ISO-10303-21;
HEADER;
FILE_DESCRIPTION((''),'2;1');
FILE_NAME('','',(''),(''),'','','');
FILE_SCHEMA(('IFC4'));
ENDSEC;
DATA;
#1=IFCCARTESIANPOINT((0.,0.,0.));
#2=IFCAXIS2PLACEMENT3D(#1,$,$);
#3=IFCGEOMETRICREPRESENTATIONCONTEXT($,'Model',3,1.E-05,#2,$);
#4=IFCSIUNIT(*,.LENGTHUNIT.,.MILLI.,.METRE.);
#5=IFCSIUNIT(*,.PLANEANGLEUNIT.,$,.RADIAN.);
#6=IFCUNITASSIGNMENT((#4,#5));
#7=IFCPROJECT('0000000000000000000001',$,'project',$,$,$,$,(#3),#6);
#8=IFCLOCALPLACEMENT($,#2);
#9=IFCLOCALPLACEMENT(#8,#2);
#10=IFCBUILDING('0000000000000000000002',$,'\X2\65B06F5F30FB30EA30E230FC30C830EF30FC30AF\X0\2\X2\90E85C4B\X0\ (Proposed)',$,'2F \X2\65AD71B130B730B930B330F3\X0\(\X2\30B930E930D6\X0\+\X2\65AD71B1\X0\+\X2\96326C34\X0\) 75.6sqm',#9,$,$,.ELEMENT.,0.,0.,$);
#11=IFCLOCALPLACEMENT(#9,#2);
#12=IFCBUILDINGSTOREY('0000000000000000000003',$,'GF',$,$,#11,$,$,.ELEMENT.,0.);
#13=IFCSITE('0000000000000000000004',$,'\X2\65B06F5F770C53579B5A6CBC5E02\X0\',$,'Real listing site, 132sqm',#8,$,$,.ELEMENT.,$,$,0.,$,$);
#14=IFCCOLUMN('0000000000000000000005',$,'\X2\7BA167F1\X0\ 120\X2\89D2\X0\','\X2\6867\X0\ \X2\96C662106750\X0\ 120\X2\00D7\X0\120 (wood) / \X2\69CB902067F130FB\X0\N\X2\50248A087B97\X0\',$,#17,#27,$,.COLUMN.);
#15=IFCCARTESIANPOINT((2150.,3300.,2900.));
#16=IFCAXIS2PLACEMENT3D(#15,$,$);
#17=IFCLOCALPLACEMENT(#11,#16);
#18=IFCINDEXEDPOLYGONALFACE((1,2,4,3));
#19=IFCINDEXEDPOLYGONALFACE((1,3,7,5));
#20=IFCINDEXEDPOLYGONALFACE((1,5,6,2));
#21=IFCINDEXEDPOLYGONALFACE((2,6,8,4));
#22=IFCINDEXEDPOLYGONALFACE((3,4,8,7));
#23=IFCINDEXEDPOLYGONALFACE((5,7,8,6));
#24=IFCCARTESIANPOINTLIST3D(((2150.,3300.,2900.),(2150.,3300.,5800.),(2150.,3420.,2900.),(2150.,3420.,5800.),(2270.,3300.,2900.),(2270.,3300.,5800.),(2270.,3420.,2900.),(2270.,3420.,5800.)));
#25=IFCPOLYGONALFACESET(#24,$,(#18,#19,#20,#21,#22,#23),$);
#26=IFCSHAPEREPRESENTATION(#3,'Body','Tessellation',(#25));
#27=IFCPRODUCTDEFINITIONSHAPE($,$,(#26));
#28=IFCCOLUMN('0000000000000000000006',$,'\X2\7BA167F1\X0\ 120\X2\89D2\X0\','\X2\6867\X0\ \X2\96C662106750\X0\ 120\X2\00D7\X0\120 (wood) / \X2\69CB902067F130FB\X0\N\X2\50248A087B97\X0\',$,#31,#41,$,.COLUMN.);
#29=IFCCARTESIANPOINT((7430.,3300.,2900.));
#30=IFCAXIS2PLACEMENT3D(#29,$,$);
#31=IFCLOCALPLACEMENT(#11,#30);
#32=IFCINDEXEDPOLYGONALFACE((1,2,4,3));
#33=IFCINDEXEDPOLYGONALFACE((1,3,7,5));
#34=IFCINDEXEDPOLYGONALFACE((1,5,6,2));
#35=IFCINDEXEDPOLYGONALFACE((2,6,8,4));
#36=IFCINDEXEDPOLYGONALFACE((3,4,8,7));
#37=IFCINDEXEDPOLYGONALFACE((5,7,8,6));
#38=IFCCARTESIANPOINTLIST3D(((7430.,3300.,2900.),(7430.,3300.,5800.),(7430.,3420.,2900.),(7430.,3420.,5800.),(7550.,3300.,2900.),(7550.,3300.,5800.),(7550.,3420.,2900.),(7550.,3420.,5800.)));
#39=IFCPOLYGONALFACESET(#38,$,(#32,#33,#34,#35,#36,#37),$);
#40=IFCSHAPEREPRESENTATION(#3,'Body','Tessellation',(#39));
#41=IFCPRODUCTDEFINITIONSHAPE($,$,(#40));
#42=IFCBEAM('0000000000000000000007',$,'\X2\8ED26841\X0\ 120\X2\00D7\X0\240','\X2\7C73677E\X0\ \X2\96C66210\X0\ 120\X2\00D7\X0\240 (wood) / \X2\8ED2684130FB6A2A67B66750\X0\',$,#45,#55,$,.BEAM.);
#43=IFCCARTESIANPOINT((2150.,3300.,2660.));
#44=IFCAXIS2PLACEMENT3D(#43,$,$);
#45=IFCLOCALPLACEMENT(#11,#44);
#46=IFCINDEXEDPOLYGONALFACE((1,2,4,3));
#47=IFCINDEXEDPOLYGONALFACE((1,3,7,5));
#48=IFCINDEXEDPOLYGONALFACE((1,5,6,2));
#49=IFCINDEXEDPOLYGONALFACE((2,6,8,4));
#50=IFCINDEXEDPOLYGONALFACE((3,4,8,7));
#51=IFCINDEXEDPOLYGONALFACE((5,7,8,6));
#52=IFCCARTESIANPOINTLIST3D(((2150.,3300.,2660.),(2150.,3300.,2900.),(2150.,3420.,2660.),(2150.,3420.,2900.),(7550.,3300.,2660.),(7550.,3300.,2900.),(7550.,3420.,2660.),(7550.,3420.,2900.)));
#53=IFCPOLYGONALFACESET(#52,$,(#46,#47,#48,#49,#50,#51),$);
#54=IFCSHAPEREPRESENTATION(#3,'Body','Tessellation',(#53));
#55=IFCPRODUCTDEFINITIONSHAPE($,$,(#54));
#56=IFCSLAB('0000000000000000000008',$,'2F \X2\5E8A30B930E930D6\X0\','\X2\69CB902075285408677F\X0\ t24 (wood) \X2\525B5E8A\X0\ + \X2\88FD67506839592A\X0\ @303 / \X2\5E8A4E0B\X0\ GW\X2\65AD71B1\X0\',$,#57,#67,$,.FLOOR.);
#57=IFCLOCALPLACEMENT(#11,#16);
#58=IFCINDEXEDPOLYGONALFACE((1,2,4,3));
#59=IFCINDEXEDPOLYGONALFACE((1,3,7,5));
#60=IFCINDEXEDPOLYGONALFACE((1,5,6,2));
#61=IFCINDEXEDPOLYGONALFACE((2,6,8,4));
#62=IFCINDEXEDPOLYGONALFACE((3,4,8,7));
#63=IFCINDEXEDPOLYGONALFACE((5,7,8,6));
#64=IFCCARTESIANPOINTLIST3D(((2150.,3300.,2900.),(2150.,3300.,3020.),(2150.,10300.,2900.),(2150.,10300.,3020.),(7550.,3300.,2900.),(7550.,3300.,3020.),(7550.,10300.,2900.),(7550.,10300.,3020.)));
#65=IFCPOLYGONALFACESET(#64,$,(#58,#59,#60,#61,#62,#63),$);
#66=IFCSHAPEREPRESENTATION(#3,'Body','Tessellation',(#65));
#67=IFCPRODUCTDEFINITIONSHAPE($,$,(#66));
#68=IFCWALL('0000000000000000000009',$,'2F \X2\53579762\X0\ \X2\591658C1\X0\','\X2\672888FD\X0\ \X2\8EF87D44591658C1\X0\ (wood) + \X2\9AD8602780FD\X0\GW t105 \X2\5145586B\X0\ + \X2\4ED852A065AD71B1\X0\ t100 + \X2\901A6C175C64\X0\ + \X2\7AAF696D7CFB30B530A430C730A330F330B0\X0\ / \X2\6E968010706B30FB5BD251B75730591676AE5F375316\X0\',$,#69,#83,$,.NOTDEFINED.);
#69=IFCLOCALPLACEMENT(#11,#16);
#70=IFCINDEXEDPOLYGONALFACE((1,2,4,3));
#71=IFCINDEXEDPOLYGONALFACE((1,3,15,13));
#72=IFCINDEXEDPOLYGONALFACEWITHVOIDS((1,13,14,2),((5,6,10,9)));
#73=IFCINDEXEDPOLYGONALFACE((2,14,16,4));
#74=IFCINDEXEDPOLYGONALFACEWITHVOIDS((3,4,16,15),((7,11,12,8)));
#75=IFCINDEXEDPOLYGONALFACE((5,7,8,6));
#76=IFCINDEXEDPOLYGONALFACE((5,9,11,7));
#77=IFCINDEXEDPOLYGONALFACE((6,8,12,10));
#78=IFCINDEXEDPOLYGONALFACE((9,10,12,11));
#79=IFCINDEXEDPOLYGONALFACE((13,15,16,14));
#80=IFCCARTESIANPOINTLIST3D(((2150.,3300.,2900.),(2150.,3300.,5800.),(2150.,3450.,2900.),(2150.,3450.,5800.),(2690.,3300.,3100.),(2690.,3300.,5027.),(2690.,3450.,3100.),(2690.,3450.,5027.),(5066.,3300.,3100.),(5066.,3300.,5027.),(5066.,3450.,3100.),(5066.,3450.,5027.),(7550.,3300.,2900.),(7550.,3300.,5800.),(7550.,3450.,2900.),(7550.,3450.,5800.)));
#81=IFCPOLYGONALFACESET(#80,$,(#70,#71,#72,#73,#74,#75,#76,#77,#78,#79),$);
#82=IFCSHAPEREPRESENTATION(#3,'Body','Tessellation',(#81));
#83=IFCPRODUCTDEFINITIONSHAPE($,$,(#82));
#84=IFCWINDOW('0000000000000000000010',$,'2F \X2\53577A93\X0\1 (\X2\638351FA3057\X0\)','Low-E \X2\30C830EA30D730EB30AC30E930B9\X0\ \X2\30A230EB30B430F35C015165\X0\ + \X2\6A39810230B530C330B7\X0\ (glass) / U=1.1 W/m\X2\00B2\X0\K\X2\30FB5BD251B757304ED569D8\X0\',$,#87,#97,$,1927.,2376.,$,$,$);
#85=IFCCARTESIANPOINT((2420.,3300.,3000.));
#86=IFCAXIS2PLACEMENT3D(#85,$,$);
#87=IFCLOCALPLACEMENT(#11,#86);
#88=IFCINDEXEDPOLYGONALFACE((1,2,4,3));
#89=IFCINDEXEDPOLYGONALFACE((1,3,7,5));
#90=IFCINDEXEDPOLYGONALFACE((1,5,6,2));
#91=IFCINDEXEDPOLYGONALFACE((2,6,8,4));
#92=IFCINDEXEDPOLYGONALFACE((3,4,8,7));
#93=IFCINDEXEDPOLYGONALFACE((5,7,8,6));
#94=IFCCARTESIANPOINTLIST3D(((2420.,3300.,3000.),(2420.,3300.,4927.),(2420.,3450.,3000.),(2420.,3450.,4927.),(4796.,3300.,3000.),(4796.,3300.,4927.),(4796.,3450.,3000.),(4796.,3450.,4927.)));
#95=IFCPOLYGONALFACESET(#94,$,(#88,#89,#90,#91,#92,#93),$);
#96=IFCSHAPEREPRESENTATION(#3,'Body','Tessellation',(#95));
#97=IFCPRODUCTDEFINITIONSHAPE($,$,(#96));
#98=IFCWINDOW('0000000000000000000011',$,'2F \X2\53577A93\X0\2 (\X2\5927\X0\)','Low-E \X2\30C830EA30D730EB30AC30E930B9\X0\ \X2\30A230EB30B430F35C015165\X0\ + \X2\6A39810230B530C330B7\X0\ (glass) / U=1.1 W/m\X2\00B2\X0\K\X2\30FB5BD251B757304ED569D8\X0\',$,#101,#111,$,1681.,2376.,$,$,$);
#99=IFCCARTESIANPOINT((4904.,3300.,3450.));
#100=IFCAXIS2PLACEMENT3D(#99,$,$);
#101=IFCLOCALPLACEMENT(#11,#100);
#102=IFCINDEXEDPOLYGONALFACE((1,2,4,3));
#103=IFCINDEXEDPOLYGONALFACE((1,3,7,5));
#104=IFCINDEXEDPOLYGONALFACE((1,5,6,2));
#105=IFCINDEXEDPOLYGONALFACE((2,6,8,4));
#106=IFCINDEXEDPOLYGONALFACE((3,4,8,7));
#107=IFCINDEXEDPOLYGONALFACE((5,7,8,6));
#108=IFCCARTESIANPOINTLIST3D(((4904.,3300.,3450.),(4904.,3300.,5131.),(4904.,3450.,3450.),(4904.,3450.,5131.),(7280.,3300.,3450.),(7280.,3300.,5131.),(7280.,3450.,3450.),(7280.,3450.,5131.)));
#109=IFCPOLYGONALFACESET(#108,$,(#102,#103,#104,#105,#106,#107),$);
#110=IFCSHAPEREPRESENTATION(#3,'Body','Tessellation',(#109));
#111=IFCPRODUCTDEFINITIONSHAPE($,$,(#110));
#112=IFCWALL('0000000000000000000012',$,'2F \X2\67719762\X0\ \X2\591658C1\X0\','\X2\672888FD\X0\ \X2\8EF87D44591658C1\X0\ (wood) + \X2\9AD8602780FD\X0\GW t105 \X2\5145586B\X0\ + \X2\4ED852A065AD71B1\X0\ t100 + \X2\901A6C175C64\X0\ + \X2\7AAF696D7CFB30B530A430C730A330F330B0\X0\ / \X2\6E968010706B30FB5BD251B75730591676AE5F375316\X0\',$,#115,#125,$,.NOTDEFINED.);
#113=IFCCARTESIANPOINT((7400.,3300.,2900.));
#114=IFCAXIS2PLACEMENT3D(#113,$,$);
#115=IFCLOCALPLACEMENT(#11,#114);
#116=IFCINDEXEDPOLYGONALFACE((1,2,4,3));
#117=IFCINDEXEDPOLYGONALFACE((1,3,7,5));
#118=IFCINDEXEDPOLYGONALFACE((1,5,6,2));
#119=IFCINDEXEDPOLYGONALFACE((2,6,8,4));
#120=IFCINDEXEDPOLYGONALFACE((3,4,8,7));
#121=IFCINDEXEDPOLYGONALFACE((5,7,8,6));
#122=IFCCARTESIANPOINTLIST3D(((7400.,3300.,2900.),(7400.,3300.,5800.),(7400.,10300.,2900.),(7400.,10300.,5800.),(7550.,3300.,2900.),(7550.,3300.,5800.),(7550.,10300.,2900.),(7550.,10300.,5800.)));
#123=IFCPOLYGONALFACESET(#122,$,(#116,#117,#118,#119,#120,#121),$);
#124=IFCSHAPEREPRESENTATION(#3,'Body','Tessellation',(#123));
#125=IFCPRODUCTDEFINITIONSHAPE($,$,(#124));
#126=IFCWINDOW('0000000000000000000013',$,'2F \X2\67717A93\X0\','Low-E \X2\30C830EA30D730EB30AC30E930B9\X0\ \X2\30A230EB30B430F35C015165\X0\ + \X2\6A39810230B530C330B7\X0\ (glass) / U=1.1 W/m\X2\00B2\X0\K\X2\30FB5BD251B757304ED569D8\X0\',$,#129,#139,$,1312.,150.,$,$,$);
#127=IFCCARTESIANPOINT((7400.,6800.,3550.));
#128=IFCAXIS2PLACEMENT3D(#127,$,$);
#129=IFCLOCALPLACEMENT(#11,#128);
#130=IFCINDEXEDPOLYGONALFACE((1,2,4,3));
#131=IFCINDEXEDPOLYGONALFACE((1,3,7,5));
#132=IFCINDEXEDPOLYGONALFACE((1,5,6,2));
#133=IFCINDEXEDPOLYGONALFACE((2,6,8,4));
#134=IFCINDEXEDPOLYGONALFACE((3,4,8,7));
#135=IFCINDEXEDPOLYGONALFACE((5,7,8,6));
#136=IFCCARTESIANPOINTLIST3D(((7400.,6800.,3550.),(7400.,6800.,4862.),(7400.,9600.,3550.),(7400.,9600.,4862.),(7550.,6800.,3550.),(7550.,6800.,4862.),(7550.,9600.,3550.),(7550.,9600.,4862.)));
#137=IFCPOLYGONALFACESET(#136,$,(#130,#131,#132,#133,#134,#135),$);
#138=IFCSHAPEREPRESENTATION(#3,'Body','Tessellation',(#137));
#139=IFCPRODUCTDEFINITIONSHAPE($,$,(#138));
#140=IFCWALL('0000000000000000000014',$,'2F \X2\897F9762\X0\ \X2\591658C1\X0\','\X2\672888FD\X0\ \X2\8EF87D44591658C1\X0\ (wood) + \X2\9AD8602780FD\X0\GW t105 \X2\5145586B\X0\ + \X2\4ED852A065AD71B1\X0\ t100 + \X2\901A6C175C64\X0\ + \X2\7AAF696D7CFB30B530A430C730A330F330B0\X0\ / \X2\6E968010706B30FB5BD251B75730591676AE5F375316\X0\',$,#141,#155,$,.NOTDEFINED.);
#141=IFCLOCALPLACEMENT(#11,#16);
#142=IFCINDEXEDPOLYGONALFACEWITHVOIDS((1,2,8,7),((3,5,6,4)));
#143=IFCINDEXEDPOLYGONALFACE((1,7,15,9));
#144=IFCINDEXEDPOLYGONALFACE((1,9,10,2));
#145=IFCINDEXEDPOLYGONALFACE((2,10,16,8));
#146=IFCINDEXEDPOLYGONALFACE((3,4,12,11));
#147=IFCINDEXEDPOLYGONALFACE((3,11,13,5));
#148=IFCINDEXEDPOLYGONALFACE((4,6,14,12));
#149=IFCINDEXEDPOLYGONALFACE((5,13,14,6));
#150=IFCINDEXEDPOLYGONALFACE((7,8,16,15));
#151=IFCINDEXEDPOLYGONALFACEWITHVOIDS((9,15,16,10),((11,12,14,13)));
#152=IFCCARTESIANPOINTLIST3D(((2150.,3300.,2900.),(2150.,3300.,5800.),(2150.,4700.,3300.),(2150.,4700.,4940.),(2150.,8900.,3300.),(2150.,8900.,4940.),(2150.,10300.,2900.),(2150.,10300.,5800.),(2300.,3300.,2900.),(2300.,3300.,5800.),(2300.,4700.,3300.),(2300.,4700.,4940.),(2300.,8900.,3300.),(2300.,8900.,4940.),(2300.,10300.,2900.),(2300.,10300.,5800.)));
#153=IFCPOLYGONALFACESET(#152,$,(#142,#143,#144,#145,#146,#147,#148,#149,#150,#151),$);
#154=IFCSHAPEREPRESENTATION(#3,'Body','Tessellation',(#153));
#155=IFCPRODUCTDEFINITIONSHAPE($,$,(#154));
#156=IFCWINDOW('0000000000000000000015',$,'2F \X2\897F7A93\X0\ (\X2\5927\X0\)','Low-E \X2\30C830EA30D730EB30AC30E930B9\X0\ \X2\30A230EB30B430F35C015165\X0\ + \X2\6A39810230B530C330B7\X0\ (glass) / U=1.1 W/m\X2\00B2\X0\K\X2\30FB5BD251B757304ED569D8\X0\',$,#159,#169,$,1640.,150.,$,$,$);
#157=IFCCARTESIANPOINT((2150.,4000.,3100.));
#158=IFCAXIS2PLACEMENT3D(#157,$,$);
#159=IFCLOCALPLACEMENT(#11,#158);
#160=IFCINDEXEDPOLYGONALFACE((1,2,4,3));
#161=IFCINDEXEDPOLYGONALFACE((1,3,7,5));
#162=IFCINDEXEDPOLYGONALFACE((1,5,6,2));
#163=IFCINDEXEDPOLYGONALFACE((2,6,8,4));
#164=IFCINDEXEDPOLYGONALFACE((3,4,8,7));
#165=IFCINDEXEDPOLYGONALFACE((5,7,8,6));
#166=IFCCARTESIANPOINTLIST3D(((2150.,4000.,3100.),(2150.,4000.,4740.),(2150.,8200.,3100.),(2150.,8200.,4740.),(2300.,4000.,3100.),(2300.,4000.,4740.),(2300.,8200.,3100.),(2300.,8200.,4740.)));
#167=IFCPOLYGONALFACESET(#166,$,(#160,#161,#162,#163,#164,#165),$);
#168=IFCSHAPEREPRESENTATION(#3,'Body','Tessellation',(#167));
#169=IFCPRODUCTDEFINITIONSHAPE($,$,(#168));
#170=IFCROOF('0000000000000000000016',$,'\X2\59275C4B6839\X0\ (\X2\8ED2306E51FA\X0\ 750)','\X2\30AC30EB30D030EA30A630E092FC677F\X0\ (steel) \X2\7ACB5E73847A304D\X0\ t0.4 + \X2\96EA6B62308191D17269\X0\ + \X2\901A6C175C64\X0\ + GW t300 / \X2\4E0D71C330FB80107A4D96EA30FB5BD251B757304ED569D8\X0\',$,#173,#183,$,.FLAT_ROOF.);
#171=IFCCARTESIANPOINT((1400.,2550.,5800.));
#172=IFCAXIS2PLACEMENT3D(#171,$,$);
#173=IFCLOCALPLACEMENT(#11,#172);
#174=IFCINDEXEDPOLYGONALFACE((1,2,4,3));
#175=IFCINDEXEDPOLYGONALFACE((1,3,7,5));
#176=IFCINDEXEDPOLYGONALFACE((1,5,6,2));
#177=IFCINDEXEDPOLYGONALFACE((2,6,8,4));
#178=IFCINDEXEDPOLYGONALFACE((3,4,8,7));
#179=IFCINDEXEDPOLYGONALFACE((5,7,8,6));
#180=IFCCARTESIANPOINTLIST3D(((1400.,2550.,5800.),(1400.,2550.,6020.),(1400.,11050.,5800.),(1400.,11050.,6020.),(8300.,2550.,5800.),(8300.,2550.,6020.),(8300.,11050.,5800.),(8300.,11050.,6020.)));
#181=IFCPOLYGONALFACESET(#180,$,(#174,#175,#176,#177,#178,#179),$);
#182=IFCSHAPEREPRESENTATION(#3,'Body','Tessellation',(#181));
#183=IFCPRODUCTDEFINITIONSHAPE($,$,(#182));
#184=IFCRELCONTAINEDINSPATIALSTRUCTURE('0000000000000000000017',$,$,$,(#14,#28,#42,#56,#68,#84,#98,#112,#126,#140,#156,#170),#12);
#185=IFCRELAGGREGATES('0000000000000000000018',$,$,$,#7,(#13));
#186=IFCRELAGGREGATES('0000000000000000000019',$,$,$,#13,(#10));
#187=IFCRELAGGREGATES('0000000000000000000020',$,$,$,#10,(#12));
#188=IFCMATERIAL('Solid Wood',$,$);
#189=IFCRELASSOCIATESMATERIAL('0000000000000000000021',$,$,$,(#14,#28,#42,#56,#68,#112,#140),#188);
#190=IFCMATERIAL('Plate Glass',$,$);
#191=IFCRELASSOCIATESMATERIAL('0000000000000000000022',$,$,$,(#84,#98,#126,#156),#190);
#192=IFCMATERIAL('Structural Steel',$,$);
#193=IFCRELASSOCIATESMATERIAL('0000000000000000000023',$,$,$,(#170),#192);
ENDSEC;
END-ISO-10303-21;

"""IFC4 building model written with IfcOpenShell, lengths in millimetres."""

from ifc_helpers import new_model, si_unit, frame, frame_2d, origin, place, context, project, spatial, rectangle, extrude, material, element, fill, save


model = new_model("IFC4")

# Units and contexts
model_context = context("Model", 3, precision=1e-05, world=origin())
ifc_project = project(units=[si_unit("LENGTHUNIT", "METRE", prefix="MILLI"), si_unit("PLANEANGLEUNIT", "RADIAN")], contexts=[model_context])

# Site, building, storey
site_placement = place(None, origin())
site = spatial("IfcSite", under=ifc_project, at=site_placement, Name="新潟県南魚沼市", ObjectType="Real listing site, 132sqm", CompositionType="ELEMENT", RefElevation=0.0)
building_placement = place(site_placement, origin())
building = spatial("IfcBuilding", under=site, at=building_placement, Name="新潟・リモートワーク2部屋 (Proposed)", ObjectType="2F 断熱シスコン(スラブ+断熱+防水) 75.6sqm", CompositionType="ELEMENT", ElevationOfRefHeight=0.0, ElevationOfTerrain=0.0)
storey_placement = place(building_placement, origin())
storey = spatial("IfcBuildingStorey", under=building, at=storey_placement, Name="GF", CompositionType="ELEMENT", Elevation=0.0)

# Columns
ifc_material_1 = material(Name="Solid Wood")
column_1_placement = place(storey_placement, frame((2150.0, 3300.0, 2900.0)))
element("IfcColumn", 1, at=column_1_placement, inside=storey, material=ifc_material_1, Name="管柱 120角", Description="桧 集成材 120×120 (wood) / 構造柱・N値計算", PredefinedType="COLUMN", context=model_context, shape_type="SweptSolid", body=[
    extrude(rectangle(XDim=120.0, YDim=120.0, at=frame_2d((60.0, 60.0))), frame((2150.0, 3300.0, 2900.0)), (0.0, 0.0, 1.0), 2900.0),
])
column_2_placement = place(storey_placement, frame((7430.0, 3300.0, 2900.0)))
element("IfcColumn", 2, at=column_2_placement, inside=storey, material=ifc_material_1, Name="管柱 120角", Description="桧 集成材 120×120 (wood) / 構造柱・N値計算", PredefinedType="COLUMN", context=model_context, shape_type="SweptSolid", body=[
    extrude(rectangle(XDim=120.0, YDim=120.0, at=frame_2d((60.0, 60.0))), frame((7430.0, 3300.0, 2900.0)), (0.0, 0.0, 1.0), 2900.0),
])

# Beam
beam_1_placement = place(storey_placement, frame((2150.0, 3300.0, 2660.0)))
element("IfcBeam", 3, at=beam_1_placement, inside=storey, material=ifc_material_1, Name="軒桁 120×240", Description="米松 集成 120×240 (wood) / 軒桁・横架材", PredefinedType="BEAM", context=model_context, shape_type="SweptSolid", body=[
    extrude(rectangle(XDim=5400.0, YDim=120.0, at=frame_2d((2700.0, 60.0))), frame((2150.0, 3300.0, 2660.0)), (0.0, 0.0, 1.0), 240.0),
])

# Slab
slab_placement = place(storey_placement, frame((2150.0, 3300.0, 2900.0)))
element("IfcSlab", 4, at=slab_placement, inside=storey, material=ifc_material_1, Name="2F 床スラブ", Description="構造用合板 t24 (wood) 剛床 + 製材根太 @303 / 床下 GW断熱", PredefinedType="FLOOR", context=model_context, shape_type="SweptSolid", body=[
    extrude(rectangle(XDim=5400.0, YDim=7000.0, at=frame_2d((2700.0, 3500.0))), frame((2150.0, 3300.0, 2900.0)), (0.0, 0.0, 1.0), 120.0),
])

# Wall, openings, windows
wall_1_placement = place(storey_placement, frame((2150.0, 3300.0, 2900.0)))
wall_1 = element("IfcWall", 5, at=wall_1_placement, inside=storey, material=ifc_material_1, Name="2F 南面 外壁", Description="木製 軸組外壁 (wood) + 高性能GW t105 充填 + 付加断熱 t100 + 通気層 + 窯業系サイディング / 準耐火・寒冷地外皮強化", PredefinedType="NOTDEFINED", context=model_context, shape_type="SweptSolid", body=[
    extrude(rectangle(XDim=5400.0, YDim=150.0, at=frame_2d((2700.0, 75.0))), frame((2150.0, 3300.0, 2900.0)), (0.0, 0.0, 1.0), 2900.0),
])
opening_1_placement = place(storey_placement, frame((2420.0, 3300.0, 3000.0)))
opening_1 = element("IfcOpeningElement", 6, at=opening_1_placement, cuts=wall_1, PredefinedType="NOTDEFINED", context=model_context, shape_type="SweptSolid", body=[
    extrude(rectangle(XDim=2376.0, YDim=150.0, at=frame_2d((1188.0, 75.0))), frame((2420.0, 3300.0, 3000.0)), (0.0, 0.0, 1.0), 1927.0),
])
opening_2_placement = place(storey_placement, frame((4904.0, 3300.0, 3450.0)))
opening_2 = element("IfcOpeningElement", 7, at=opening_2_placement, cuts=wall_1, PredefinedType="NOTDEFINED", context=model_context, shape_type="SweptSolid", body=[
    extrude(rectangle(XDim=2376.0, YDim=150.0, at=frame_2d((1188.0, 75.0))), frame((4904.0, 3300.0, 3450.0)), (0.0, 0.0, 1.0), 1681.0),
])
ifc_material_2 = material(Name="Plate Glass")
window_1_placement = place(storey_placement, frame((2420.0, 3300.0, 3000.0)))
window_1 = element("IfcWindow", 8, at=window_1_placement, inside=storey, material=ifc_material_2, Name="2F 南窓1 (掃出し)", Description="Low-E トリプルガラス アルゴン封入 + 樹脂サッシ (glass) / U=1.1 W/m²K・寒冷地仕様", OverallHeight=1927.0, OverallWidth=2376.0, context=model_context, shape_type="SweptSolid", body=[
    extrude(rectangle(XDim=2376.0, YDim=150.0, at=frame_2d((1188.0, 75.0))), frame((2420.0, 3300.0, 3000.0)), (0.0, 0.0, 1.0), 1927.0),
])
fill(opening_1, window_1)
window_2_placement = place(storey_placement, frame((4904.0, 3300.0, 3450.0)))
window_2 = element("IfcWindow", 9, at=window_2_placement, inside=storey, material=ifc_material_2, Name="2F 南窓2 (大)", Description="Low-E トリプルガラス アルゴン封入 + 樹脂サッシ (glass) / U=1.1 W/m²K・寒冷地仕様", OverallHeight=1681.0, OverallWidth=2376.0, context=model_context, shape_type="SweptSolid", body=[
    extrude(rectangle(XDim=2376.0, YDim=150.0, at=frame_2d((1188.0, 75.0))), frame((4904.0, 3300.0, 3450.0)), (0.0, 0.0, 1.0), 1681.0),
])
fill(opening_2, window_2)

# Walls, openings, windows
wall_2_placement = place(storey_placement, frame((7400.0, 3300.0, 2900.0)))
wall_2 = element("IfcWall", 10, at=wall_2_placement, inside=storey, material=ifc_material_1, Name="2F 東面 外壁", Description="木製 軸組外壁 (wood) + 高性能GW t105 充填 + 付加断熱 t100 + 通気層 + 窯業系サイディング / 準耐火・寒冷地外皮強化", PredefinedType="NOTDEFINED", context=model_context, shape_type="SweptSolid", body=[
    extrude(rectangle(XDim=150.0, YDim=7000.0, at=frame_2d((75.0, 3500.0))), frame((7400.0, 3300.0, 2900.0)), (0.0, 0.0, 1.0), 2900.0),
])
opening_3_placement = place(storey_placement, frame((7400.0, 6800.0, 3550.0)))
opening_3 = element("IfcOpeningElement", 11, at=opening_3_placement, cuts=wall_2, PredefinedType="NOTDEFINED", context=model_context, shape_type="SweptSolid", body=[
    extrude(rectangle(XDim=150.0, YDim=2800.0, at=frame_2d((75.0, 1400.0))), frame((7400.0, 6800.0, 3550.0)), (0.0, 0.0, 1.0), 1312.0),
])
window_3_placement = place(storey_placement, frame((7400.0, 6800.0, 3550.0)))
window_3 = element("IfcWindow", 12, at=window_3_placement, inside=storey, material=ifc_material_2, Name="2F 東窓", Description="Low-E トリプルガラス アルゴン封入 + 樹脂サッシ (glass) / U=1.1 W/m²K・寒冷地仕様", OverallHeight=1312.0, OverallWidth=150.0, context=model_context, shape_type="SweptSolid", body=[
    extrude(rectangle(XDim=150.0, YDim=2800.0, at=frame_2d((75.0, 1400.0))), frame((7400.0, 6800.0, 3550.0)), (0.0, 0.0, 1.0), 1312.0),
])
fill(opening_3, window_3)
wall_3_placement = place(storey_placement, frame((2150.0, 3300.0, 2900.0)))
wall_3 = element("IfcWall", 13, at=wall_3_placement, inside=storey, material=ifc_material_1, Name="2F 西面 外壁", Description="木製 軸組外壁 (wood) + 高性能GW t105 充填 + 付加断熱 t100 + 通気層 + 窯業系サイディング / 準耐火・寒冷地外皮強化", PredefinedType="NOTDEFINED", context=model_context, shape_type="SweptSolid", body=[
    extrude(rectangle(XDim=150.0, YDim=7000.0, at=frame_2d((75.0, 3500.0))), frame((2150.0, 3300.0, 2900.0)), (0.0, 0.0, 1.0), 2900.0),
])
opening_4_placement = place(storey_placement, frame((2150.0, 4000.0, 3100.0)))
opening_4 = element("IfcOpeningElement", 14, at=opening_4_placement, cuts=wall_3, PredefinedType="NOTDEFINED", context=model_context, shape_type="SweptSolid", body=[
    extrude(rectangle(XDim=150.0, YDim=4200.0, at=frame_2d((75.0, 2100.0))), frame((2150.0, 4000.0, 3100.0)), (0.0, 0.0, 1.0), 1640.0),
])
window_4_placement = place(storey_placement, frame((2150.0, 4000.0, 3100.0)))
window_4 = element("IfcWindow", 15, at=window_4_placement, inside=storey, material=ifc_material_2, Name="2F 西窓 (大)", Description="Low-E トリプルガラス アルゴン封入 + 樹脂サッシ (glass) / U=1.1 W/m²K・寒冷地仕様", OverallHeight=1640.0, OverallWidth=150.0, context=model_context, shape_type="SweptSolid", body=[
    extrude(rectangle(XDim=150.0, YDim=4200.0, at=frame_2d((75.0, 2100.0))), frame((2150.0, 4000.0, 3100.0)), (0.0, 0.0, 1.0), 1640.0),
])
fill(opening_4, window_4)

# Roof
ifc_material_3 = material(Name="Structural Steel")
roof_placement = place(storey_placement, frame((1400.0, 2550.0, 5800.0)))
element("IfcRoof", 16, at=roof_placement, inside=storey, material=ifc_material_3, Name="大屋根 (軒の出 750)", Description="ガルバリウム鋼板 (steel) 立平葺き t0.4 + 雪止め金物 + 通気層 + GW t300 / 不燃・耐積雪・寒冷地仕様", PredefinedType="FLAT_ROOF", context=model_context, shape_type="SweptSolid", body=[
    extrude(rectangle(XDim=6900.0, YDim=8500.0, at=frame_2d((3450.0, 4250.0))), frame((1400.0, 2550.0, 5800.0)), (0.0, 0.0, 1.0), 220.0),
])

save(model, "model.ifc")
